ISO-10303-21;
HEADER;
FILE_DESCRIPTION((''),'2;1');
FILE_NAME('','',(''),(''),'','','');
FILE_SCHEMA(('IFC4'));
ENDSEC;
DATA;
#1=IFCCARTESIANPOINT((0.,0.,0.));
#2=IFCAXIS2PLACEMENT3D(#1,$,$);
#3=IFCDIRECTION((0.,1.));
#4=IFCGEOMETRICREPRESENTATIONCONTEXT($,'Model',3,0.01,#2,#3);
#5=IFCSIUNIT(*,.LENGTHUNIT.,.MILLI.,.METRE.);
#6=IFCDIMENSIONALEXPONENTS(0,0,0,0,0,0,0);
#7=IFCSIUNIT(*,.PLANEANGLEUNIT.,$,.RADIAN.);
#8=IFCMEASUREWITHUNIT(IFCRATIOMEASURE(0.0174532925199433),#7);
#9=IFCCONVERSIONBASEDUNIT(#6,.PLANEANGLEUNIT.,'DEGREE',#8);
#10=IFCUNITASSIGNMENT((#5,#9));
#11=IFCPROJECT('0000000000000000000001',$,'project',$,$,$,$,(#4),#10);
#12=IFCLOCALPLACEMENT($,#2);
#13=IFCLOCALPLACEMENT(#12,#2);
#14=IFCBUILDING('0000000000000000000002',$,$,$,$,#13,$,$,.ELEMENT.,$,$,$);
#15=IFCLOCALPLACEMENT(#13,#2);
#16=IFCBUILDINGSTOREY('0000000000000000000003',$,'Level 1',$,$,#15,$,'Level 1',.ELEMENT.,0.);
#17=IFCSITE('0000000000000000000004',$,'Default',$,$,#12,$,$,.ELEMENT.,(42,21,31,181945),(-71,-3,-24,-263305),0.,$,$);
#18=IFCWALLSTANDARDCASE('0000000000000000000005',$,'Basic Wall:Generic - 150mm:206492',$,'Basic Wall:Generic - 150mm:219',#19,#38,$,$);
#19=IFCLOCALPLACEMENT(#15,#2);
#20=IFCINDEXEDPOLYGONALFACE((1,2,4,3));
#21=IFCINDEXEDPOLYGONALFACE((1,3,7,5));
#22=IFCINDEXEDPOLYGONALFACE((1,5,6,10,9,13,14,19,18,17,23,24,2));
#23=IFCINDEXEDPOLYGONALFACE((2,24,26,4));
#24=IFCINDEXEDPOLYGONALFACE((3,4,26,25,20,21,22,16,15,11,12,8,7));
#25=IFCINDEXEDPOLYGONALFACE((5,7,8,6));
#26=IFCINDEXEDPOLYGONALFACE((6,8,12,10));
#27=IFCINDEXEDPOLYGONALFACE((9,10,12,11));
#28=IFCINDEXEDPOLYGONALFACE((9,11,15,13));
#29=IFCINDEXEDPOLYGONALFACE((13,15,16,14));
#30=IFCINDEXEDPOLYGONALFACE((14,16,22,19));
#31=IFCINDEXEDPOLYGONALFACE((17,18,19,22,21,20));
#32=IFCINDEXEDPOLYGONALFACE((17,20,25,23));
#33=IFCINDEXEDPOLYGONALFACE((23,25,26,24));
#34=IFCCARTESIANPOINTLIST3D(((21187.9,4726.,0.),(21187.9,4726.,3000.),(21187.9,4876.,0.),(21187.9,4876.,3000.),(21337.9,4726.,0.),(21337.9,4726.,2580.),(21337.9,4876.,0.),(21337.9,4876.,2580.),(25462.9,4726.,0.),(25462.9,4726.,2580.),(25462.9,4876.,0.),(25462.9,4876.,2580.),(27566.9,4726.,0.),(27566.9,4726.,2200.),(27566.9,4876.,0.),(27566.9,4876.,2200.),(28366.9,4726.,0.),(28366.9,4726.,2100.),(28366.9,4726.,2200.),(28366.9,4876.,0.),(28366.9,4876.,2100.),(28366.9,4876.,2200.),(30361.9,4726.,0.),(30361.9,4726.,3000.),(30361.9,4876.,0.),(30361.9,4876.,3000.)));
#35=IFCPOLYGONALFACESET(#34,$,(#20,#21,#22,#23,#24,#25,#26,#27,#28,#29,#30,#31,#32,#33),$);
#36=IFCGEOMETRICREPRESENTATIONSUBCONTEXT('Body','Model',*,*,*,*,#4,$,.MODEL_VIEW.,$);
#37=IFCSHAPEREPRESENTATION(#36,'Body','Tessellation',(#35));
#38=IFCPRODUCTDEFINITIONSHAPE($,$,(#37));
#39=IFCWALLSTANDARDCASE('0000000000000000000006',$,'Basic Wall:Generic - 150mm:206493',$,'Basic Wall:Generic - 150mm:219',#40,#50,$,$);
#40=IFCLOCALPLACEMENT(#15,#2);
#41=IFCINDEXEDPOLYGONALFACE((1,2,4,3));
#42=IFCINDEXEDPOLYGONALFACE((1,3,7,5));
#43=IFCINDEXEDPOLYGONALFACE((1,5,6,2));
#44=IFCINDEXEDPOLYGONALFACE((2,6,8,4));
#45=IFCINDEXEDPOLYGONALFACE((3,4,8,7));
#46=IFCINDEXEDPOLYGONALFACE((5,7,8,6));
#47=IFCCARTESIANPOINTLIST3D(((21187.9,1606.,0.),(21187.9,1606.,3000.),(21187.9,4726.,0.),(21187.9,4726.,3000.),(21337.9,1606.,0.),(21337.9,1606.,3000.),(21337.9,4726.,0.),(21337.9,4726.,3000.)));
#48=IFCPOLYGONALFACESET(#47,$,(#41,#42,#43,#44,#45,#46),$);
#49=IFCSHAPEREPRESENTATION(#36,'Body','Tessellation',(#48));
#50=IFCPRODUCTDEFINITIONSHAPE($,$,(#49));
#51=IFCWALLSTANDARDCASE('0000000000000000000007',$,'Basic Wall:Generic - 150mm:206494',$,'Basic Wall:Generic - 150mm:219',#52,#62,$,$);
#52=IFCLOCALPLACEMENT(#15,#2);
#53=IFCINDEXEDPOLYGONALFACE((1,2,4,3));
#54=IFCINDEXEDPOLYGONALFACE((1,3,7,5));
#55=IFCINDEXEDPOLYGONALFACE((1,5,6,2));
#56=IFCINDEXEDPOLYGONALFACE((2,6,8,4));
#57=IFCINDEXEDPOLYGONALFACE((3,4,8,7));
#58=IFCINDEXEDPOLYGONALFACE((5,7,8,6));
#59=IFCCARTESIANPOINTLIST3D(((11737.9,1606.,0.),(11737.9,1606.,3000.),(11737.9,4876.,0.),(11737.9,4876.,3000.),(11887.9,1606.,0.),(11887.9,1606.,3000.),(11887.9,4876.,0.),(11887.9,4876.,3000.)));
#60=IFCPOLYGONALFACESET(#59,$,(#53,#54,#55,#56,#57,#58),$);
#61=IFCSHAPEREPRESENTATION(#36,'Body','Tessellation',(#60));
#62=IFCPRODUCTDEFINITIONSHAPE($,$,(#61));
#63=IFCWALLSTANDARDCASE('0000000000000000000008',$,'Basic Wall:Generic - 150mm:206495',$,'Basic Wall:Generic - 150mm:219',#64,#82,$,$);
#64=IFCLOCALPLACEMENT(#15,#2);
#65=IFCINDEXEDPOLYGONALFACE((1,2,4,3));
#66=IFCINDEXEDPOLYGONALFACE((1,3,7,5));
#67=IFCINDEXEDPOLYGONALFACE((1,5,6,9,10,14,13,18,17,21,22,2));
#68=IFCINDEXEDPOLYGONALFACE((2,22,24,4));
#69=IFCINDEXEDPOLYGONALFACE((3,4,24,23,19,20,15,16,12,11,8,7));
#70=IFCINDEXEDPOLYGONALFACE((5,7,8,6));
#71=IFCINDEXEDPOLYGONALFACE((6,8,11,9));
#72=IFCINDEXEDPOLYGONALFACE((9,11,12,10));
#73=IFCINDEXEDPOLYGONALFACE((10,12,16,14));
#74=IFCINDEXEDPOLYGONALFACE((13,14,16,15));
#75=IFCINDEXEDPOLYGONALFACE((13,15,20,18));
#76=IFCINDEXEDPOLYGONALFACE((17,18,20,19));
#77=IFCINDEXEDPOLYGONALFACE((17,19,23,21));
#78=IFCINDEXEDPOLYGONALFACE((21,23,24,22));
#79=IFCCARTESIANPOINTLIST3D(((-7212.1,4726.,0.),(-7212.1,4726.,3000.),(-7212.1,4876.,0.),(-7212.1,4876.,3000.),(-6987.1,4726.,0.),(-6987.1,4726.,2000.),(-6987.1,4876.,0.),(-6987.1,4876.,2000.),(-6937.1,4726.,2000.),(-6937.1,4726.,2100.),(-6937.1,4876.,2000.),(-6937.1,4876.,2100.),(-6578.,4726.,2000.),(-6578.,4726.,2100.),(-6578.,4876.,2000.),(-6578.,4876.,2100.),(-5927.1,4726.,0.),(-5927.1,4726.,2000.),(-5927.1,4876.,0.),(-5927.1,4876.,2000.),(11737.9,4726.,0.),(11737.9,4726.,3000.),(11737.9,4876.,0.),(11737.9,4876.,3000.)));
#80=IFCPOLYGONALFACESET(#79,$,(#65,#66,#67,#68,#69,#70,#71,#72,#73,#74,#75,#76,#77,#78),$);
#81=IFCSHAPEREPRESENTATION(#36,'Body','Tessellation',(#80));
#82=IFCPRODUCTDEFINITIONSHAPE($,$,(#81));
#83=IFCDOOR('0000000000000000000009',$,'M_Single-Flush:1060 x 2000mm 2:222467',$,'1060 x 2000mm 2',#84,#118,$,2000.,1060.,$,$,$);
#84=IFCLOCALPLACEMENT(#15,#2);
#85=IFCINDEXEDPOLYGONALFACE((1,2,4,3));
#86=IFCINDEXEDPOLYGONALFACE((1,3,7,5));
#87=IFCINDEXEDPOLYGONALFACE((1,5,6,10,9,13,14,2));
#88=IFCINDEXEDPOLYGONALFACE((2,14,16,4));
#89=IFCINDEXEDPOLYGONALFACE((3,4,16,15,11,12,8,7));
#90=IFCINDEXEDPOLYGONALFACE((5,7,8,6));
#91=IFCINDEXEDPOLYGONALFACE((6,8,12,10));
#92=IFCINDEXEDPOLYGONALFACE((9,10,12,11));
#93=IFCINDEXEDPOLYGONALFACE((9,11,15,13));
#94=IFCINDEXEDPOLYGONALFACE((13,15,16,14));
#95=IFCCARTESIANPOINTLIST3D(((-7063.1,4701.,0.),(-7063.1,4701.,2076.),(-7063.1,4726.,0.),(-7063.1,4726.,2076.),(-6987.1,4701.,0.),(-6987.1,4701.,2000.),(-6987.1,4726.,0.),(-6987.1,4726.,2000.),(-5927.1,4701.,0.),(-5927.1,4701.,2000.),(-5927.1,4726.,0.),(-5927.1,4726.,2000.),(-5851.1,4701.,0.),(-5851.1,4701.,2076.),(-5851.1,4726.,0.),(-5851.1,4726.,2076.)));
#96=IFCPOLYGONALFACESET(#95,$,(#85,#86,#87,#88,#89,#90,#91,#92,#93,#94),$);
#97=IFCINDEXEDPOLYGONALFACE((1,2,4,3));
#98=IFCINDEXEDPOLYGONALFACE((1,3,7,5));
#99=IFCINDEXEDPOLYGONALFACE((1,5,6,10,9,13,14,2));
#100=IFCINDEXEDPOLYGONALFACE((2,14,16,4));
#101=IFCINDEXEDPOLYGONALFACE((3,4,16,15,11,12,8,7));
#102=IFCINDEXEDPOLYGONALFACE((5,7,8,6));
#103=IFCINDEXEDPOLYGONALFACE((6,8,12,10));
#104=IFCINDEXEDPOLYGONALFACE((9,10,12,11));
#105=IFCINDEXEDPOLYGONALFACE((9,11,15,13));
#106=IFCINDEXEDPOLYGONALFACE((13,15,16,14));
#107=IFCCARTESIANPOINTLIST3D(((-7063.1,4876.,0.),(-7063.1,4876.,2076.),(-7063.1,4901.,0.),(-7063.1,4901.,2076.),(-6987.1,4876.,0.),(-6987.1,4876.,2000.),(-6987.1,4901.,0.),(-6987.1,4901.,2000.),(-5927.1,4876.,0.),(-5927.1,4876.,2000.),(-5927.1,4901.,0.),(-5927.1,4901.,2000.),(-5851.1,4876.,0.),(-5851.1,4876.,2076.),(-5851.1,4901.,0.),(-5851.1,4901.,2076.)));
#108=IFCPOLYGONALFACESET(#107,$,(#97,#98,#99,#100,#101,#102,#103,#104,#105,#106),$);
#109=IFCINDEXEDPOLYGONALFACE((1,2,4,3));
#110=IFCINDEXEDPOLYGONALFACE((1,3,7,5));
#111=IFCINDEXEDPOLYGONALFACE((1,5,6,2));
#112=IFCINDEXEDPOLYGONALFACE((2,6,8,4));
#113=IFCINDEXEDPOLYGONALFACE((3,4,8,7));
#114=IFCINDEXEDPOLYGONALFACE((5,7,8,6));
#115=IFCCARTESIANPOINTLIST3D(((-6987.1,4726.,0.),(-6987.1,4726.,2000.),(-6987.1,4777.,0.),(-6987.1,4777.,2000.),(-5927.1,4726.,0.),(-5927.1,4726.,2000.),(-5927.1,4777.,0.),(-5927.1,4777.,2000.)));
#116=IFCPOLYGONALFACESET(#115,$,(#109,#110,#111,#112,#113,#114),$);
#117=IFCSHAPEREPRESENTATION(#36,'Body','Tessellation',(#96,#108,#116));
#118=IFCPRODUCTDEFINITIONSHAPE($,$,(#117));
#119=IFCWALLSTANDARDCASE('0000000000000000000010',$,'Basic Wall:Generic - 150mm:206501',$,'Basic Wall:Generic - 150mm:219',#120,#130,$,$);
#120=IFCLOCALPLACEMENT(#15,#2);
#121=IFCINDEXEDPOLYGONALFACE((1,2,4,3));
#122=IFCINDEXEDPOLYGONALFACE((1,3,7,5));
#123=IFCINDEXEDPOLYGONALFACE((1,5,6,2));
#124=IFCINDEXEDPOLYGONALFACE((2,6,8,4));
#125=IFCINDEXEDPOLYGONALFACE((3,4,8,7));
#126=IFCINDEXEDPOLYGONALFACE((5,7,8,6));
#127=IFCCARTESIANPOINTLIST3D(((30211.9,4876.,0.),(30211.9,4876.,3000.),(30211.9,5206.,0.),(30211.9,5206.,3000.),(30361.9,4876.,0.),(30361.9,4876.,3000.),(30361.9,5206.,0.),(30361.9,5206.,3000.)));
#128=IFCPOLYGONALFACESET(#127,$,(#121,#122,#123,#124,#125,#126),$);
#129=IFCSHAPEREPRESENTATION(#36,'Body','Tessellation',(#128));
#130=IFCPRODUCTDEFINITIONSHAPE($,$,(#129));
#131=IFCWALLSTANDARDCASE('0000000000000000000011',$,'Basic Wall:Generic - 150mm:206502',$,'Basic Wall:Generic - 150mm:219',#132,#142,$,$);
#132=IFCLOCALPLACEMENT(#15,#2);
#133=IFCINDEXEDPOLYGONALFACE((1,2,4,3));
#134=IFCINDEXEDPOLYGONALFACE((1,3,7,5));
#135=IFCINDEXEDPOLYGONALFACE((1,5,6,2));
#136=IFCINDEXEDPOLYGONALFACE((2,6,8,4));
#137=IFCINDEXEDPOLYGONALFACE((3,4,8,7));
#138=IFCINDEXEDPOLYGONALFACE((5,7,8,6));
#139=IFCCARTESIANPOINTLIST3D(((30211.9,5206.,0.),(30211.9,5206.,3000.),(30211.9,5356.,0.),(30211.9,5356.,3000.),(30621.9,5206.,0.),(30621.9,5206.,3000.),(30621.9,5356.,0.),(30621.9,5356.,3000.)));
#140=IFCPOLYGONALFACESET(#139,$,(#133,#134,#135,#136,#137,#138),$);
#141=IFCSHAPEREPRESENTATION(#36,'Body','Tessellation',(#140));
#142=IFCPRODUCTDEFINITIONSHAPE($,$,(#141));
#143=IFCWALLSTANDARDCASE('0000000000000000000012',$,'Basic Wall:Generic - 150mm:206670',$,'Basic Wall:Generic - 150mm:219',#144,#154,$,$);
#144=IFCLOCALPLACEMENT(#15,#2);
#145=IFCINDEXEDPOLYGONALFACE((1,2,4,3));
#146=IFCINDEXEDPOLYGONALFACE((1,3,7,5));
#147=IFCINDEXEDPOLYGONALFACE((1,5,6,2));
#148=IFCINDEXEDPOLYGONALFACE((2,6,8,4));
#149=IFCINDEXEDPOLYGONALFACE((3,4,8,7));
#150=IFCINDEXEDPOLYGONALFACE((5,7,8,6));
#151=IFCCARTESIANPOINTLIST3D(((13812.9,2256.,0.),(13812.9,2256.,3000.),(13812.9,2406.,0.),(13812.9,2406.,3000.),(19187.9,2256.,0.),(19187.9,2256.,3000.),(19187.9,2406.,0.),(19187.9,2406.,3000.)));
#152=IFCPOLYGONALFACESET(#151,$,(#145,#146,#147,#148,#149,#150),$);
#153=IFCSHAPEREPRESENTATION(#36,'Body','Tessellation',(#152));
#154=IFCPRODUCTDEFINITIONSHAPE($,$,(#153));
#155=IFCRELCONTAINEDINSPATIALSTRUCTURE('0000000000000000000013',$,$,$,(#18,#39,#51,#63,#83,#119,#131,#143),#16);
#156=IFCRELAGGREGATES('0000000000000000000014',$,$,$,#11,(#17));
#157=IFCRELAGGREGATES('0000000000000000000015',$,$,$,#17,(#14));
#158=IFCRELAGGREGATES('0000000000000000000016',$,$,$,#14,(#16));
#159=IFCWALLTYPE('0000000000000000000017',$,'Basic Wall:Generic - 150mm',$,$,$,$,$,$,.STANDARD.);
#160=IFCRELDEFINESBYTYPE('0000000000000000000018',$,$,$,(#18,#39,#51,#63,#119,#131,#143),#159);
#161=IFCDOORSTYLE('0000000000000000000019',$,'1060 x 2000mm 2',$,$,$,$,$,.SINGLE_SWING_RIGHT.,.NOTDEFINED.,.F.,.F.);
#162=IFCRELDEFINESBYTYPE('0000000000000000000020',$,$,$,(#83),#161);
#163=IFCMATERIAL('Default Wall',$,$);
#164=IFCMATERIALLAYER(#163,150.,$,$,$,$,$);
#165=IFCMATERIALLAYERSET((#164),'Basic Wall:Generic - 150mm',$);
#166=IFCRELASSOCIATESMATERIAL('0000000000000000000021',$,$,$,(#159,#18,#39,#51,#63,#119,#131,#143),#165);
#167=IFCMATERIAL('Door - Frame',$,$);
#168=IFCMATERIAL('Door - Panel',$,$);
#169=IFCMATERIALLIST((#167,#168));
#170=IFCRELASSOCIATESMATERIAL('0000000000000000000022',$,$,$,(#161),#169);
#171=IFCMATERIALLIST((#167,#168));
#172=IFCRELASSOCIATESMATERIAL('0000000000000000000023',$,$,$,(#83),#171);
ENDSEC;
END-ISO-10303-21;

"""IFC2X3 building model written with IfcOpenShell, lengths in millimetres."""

from ifc_helpers import new_model, entity, si_unit, converted_unit, direction, frame, frame_2d, origin, place, context, subcontext, project, spatial, polyline, rectangle, outline, extrude, source, transform, mapped, material, material_list, layer, layer_set, layer_usage, type_object, type_shapes, element, fill, save


model = new_model("IFC2X3")

# Units and contexts
model_context = context("Model", 3, precision=0.01, world=origin(), true_north=direction((0.0, 1.0)))
body_context = subcontext(model_context, "Body", "Model", "MODEL_VIEW")
ifc_project = project(units=[si_unit("LENGTHUNIT", "METRE", prefix="MILLI"), converted_unit("PLANEANGLEUNIT", "DEGREE", entity("IfcRatioMeasure", 0.0174532925199433), si_unit("PLANEANGLEUNIT", "RADIAN"), dimensions=[0, 0, 0, 0, 0, 0, 0])], contexts=[model_context])

# Site, building, storey
site_placement = place(None, origin())
site = spatial("IfcSite", under=ifc_project, at=site_placement, Name="Default", CompositionType="ELEMENT", RefLatitude=(42, 21, 31, 181945), RefLongitude=(-71, -3, -24, -263305), RefElevation=0.0)
building_placement = place(site_placement, origin())
building = spatial("IfcBuilding", under=site, at=building_placement, CompositionType="ELEMENT")
storey_placement = place(building_placement, origin())
storey = spatial("IfcBuildingStorey", under=building, at=storey_placement, Name="Level 1", LongName="Level 1", CompositionType="ELEMENT", Elevation=0.0)

# Wall, openings
ifc_material_1 = material(Name="Default Wall")
ifc_layer = layer(ifc_material_1, 150.0)
ifc_layer_set = layer_set([ifc_layer], Name="Basic Wall:Generic - 150mm")
ifc_layer_usage_1 = layer_usage(ifc_layer_set, "AXIS2", "NEGATIVE", 75.0)
wall_type = type_object("IfcWallType", Name="Basic Wall:Generic - 150mm", PredefinedType="STANDARD", material=ifc_layer_set)
wall_1_placement = place(storey_placement, frame((30361.9, 4801.0, 0.0), z_axis=(0.0, 0.0, 1.0), x_axis=(-1.0, 0.0, 0.0)))
wall_1 = element("IfcWallStandardCase", 1, at=wall_1_placement, inside=storey, type_object=wall_type, material=ifc_layer_usage_1, Name="Basic Wall:Generic - 150mm:206492", ObjectType="Basic Wall:Generic - 150mm:219", context=body_context, shape_type="SweptSolid", body=[
    extrude(rectangle(XDim=9174.0, YDim=150.0, at=frame_2d((4587.0, 0.0), x_axis=(-1.0, 0.0))), origin(), (0.0, 0.0, 1.0), 3000.0),
])
opening_1_placement = place(wall_1_placement, origin())
element("IfcOpeningElement", 2, at=opening_1_placement, cuts=wall_1, ObjectType="Opening", context=body_context, shape_type="SweptSolid", body=[
    extrude(rectangle(XDim=2100.0, YDim=700.0, at=frame_2d((0.0, 0.0), x_axis=(0.0, 1.0))), frame((2345.0, 75.0, 1050.0), z_axis=(0.0, -1.0, 0.0), x_axis=(1.0, 0.0, 0.0)), (0.0, 0.0, 1.0), 150.0),
])
opening_2_placement = place(wall_1_placement, origin())
element("IfcOpeningElement", 3, at=opening_2_placement, cuts=wall_1, ObjectType="Opening", context=body_context, shape_type="SweptSolid", body=[
    extrude(rectangle(XDim=2580.0, YDim=4125.0, at=frame_2d((0.0, 0.0), x_axis=(0.0, 1.0))), frame((6961.5, 75.0, 1290.0), z_axis=(0.0, -1.0, 0.0), x_axis=(1.0, 0.0, 0.0)), (0.0, 0.0, 1.0), 150.0),
])
opening_3_placement = place(wall_1_placement, frame((1995.0, -75.0, 0.0)))
element("IfcOpeningElement", 4, at=opening_3_placement, cuts=wall_1, ObjectType="Opening", context=body_context, shape_type="SweptSolid", body=[
    extrude(rectangle(XDim=2200.0, YDim=800.0, at=frame_2d((1100.0, 400.0), x_axis=(1.0, 0.0))), frame((0.0, 0.0, 0.0), z_axis=(0.0, 1.0, 0.0), x_axis=(0.0, 0.0, 1.0)), (0.0, 0.0, 1.0), 150.0),
])

# Walls
ifc_layer_usage_2 = layer_usage(ifc_layer_set, "AXIS2", "NEGATIVE", 75.0)
wall_2_placement = place(storey_placement, frame((21262.9, 4726.0, 0.0), z_axis=(0.0, 0.0, 1.0), x_axis=(0.0, -1.0, 0.0)))
element("IfcWallStandardCase", 5, at=wall_2_placement, inside=storey, type_object=wall_type, material=ifc_layer_usage_2, Name="Basic Wall:Generic - 150mm:206493", ObjectType="Basic Wall:Generic - 150mm:219", context=body_context, shape_type="SweptSolid", body=[
    extrude(rectangle(XDim=3120.0, YDim=150.0, at=frame_2d((1560.0, 0.0), x_axis=(-1.0, 0.0))), origin(), (0.0, 0.0, 1.0), 3000.0),
])
ifc_layer_usage_3 = layer_usage(ifc_layer_set, "AXIS2", "NEGATIVE", 75.0)
wall_3_placement = place(storey_placement, frame((11812.9, 1606.0, 0.0), z_axis=(0.0, 0.0, 1.0), x_axis=(0.0, 1.0, 0.0)))
element("IfcWallStandardCase", 6, at=wall_3_placement, inside=storey, type_object=wall_type, material=ifc_layer_usage_3, Name="Basic Wall:Generic - 150mm:206494", ObjectType="Basic Wall:Generic - 150mm:219", context=body_context, shape_type="SweptSolid", body=[
    extrude(rectangle(XDim=3270.0, YDim=150.0, at=frame_2d((1635.0, 0.0), x_axis=(-1.0, 0.0))), origin(), (0.0, 0.0, 1.0), 3000.0),
])

# Wall, openings, door
ifc_layer_usage_4 = layer_usage(ifc_layer_set, "AXIS2", "NEGATIVE", 75.0)
wall_4_placement = place(storey_placement, frame((11737.9, 4801.0, 0.0), z_axis=(0.0, 0.0, 1.0), x_axis=(-1.0, 0.0, 0.0)))
wall_4 = element("IfcWallStandardCase", 7, at=wall_4_placement, inside=storey, type_object=wall_type, material=ifc_layer_usage_4, Name="Basic Wall:Generic - 150mm:206495", ObjectType="Basic Wall:Generic - 150mm:219", context=body_context, shape_type="SweptSolid", body=[
    extrude(rectangle(XDim=18950.0, YDim=150.0, at=frame_2d((9475.0, 0.0), x_axis=(-1.0, 0.0))), origin(), (0.0, 0.0, 1.0), 3000.0),
])
opening_4_placement = place(wall_4_placement, origin())
element("IfcOpeningElement", 8, at=opening_4_placement, cuts=wall_4, ObjectType="Opening", context=body_context, shape_type="SweptSolid", body=[
    extrude(rectangle(XDim=2100.0, YDim=359.1, at=frame_2d((0.0, 0.0), x_axis=(0.0, 1.0))), frame((18495.5, 75.0, 1050.0), z_axis=(0.0, -1.0, 0.0), x_axis=(1.0, 0.0, 0.0)), (0.0, 0.0, 1.0), 150.0),
])
opening_5_placement = place(wall_4_placement, frame((17665.0, -75.0, 0.0)))
opening_5 = element("IfcOpeningElement", 9, at=opening_5_placement, cuts=wall_4, ObjectType="Opening", context=body_context, shape_type="SweptSolid", body=[
    extrude(rectangle(XDim=1060.0, YDim=2000.0, at=frame_2d((1000.0, 530.0), x_axis=(0.0, 1.0))), frame((0.0, 0.0, 0.0), z_axis=(0.0, 1.0, 0.0), x_axis=(0.0, 0.0, 1.0)), (0.0, 0.0, 1.0), 150.0),
])
ifc_material_2 = material(Name="Door - Frame")
ifc_material_3 = material(Name="Door - Panel")
ifc_material_list_1 = material_list([ifc_material_2, ifc_material_3])
ifc_material_list_2 = material_list([ifc_material_2, ifc_material_3])
door_style_1 = type_object("IfcDoorStyle", Name="1060 x 2000mm 2", ConstructionType="NOTDEFINED", OperationType="SINGLE_SWING_RIGHT", ParameterTakesPrecedence=False, Sizeable=False, material=ifc_material_list_2)
shared_shape_1 = source(origin(), body_context, "Body", "SweptSolid", [
    extrude(outline(polyline([(-606.0, -1057.0), (606.0, -1057.0), (606.0, 1019.0), (530.0, 1019.0), (530.0, -981.0), (-530.0, -981.0), (-530.0, 1019.0), (-606.0, 1019.0), (-606.0, -1057.0)])), frame((530.0, 150.0, 1019.0), z_axis=(0.0, 1.0, 0.0), x_axis=(1.0, 0.0, 0.0)), (0.0, 0.0, 1.0), 25.0),
    extrude(outline(polyline([(-1057.0, -606.0), (1019.0, -606.0), (1019.0, -530.0), (-981.0, -530.0), (-981.0, 530.0), (1019.0, 530.0), (1019.0, 606.0), (-1057.0, 606.0), (-1057.0, -606.0)])), frame((530.0, -25.0, 1019.0), z_axis=(0.0, 1.0, 0.0), x_axis=(0.0, 0.0, -1.0)), (0.0, 0.0, 1.0), 25.0),
    extrude(rectangle(XDim=51.0, YDim=1060.0, at=frame_2d((0.0, 0.0), x_axis=(1.0, 0.0))), frame((530.0, 124.5, 0.0), z_axis=(0.0, 0.0, 1.0), x_axis=(0.0, 1.0, 0.0)), (0.0, 0.0, 1.0), 2000.0),
])
type_shapes(door_style_1, [shared_shape_1])
door_1_placement = place(opening_5_placement, origin())
door_1 = element("IfcDoor", 10, at=door_1_placement, inside=storey, type_object=door_style_1, material=ifc_material_list_1, Name="M_Single-Flush:1060 x 2000mm 2:222467", ObjectType="1060 x 2000mm 2", OverallHeight=2000.0, OverallWidth=1060.0, context=body_context, shape_type="MappedRepresentation", body=[
    mapped(shared_shape_1, transform((0.0, 0.0, 0.0), scale=1.0)),
])
fill(opening_5, door_1)

# Walls
ifc_layer_usage_5 = layer_usage(ifc_layer_set, "AXIS2", "NEGATIVE", 75.0)
wall_5_placement = place(storey_placement, frame((30286.9, 4876.0, 0.0), z_axis=(0.0, 0.0, 1.0), x_axis=(0.0, 1.0, 0.0)))
element("IfcWallStandardCase", 11, at=wall_5_placement, inside=storey, type_object=wall_type, material=ifc_layer_usage_5, Name="Basic Wall:Generic - 150mm:206501", ObjectType="Basic Wall:Generic - 150mm:219", context=body_context, shape_type="SweptSolid", body=[
    extrude(rectangle(XDim=330.0, YDim=150.0, at=frame_2d((165.0, 0.0), x_axis=(-1.0, 0.0))), origin(), (0.0, 0.0, 1.0), 3000.0),
])
ifc_layer_usage_6 = layer_usage(ifc_layer_set, "AXIS2", "NEGATIVE", 75.0)
wall_6_placement = place(storey_placement, frame((30211.9, 5281.0, 0.0)))
element("IfcWallStandardCase", 12, at=wall_6_placement, inside=storey, type_object=wall_type, material=ifc_layer_usage_6, Name="Basic Wall:Generic - 150mm:206502", ObjectType="Basic Wall:Generic - 150mm:219", context=body_context, shape_type="SweptSolid", body=[
    extrude(rectangle(XDim=410.0, YDim=150.0, at=frame_2d((205.0, 0.0), x_axis=(-1.0, 0.0))), origin(), (0.0, 0.0, 1.0), 3000.0),
])
ifc_layer_usage_7 = layer_usage(ifc_layer_set, "AXIS2", "NEGATIVE", 75.0)
wall_7_placement = place(storey_placement, frame((13812.9, 2331.0, 0.0)))
element("IfcWallStandardCase", 13, at=wall_7_placement, inside=storey, type_object=wall_type, material=ifc_layer_usage_7, Name="Basic Wall:Generic - 150mm:206670", ObjectType="Basic Wall:Generic - 150mm:219", context=body_context, shape_type="SweptSolid", body=[
    extrude(rectangle(XDim=5375.0, YDim=150.0, at=frame_2d((2687.5, 0.0), x_axis=(-1.0, 0.0))), origin(), (0.0, 0.0, 1.0), 3000.0),
])

save(model, "model.ifc")
